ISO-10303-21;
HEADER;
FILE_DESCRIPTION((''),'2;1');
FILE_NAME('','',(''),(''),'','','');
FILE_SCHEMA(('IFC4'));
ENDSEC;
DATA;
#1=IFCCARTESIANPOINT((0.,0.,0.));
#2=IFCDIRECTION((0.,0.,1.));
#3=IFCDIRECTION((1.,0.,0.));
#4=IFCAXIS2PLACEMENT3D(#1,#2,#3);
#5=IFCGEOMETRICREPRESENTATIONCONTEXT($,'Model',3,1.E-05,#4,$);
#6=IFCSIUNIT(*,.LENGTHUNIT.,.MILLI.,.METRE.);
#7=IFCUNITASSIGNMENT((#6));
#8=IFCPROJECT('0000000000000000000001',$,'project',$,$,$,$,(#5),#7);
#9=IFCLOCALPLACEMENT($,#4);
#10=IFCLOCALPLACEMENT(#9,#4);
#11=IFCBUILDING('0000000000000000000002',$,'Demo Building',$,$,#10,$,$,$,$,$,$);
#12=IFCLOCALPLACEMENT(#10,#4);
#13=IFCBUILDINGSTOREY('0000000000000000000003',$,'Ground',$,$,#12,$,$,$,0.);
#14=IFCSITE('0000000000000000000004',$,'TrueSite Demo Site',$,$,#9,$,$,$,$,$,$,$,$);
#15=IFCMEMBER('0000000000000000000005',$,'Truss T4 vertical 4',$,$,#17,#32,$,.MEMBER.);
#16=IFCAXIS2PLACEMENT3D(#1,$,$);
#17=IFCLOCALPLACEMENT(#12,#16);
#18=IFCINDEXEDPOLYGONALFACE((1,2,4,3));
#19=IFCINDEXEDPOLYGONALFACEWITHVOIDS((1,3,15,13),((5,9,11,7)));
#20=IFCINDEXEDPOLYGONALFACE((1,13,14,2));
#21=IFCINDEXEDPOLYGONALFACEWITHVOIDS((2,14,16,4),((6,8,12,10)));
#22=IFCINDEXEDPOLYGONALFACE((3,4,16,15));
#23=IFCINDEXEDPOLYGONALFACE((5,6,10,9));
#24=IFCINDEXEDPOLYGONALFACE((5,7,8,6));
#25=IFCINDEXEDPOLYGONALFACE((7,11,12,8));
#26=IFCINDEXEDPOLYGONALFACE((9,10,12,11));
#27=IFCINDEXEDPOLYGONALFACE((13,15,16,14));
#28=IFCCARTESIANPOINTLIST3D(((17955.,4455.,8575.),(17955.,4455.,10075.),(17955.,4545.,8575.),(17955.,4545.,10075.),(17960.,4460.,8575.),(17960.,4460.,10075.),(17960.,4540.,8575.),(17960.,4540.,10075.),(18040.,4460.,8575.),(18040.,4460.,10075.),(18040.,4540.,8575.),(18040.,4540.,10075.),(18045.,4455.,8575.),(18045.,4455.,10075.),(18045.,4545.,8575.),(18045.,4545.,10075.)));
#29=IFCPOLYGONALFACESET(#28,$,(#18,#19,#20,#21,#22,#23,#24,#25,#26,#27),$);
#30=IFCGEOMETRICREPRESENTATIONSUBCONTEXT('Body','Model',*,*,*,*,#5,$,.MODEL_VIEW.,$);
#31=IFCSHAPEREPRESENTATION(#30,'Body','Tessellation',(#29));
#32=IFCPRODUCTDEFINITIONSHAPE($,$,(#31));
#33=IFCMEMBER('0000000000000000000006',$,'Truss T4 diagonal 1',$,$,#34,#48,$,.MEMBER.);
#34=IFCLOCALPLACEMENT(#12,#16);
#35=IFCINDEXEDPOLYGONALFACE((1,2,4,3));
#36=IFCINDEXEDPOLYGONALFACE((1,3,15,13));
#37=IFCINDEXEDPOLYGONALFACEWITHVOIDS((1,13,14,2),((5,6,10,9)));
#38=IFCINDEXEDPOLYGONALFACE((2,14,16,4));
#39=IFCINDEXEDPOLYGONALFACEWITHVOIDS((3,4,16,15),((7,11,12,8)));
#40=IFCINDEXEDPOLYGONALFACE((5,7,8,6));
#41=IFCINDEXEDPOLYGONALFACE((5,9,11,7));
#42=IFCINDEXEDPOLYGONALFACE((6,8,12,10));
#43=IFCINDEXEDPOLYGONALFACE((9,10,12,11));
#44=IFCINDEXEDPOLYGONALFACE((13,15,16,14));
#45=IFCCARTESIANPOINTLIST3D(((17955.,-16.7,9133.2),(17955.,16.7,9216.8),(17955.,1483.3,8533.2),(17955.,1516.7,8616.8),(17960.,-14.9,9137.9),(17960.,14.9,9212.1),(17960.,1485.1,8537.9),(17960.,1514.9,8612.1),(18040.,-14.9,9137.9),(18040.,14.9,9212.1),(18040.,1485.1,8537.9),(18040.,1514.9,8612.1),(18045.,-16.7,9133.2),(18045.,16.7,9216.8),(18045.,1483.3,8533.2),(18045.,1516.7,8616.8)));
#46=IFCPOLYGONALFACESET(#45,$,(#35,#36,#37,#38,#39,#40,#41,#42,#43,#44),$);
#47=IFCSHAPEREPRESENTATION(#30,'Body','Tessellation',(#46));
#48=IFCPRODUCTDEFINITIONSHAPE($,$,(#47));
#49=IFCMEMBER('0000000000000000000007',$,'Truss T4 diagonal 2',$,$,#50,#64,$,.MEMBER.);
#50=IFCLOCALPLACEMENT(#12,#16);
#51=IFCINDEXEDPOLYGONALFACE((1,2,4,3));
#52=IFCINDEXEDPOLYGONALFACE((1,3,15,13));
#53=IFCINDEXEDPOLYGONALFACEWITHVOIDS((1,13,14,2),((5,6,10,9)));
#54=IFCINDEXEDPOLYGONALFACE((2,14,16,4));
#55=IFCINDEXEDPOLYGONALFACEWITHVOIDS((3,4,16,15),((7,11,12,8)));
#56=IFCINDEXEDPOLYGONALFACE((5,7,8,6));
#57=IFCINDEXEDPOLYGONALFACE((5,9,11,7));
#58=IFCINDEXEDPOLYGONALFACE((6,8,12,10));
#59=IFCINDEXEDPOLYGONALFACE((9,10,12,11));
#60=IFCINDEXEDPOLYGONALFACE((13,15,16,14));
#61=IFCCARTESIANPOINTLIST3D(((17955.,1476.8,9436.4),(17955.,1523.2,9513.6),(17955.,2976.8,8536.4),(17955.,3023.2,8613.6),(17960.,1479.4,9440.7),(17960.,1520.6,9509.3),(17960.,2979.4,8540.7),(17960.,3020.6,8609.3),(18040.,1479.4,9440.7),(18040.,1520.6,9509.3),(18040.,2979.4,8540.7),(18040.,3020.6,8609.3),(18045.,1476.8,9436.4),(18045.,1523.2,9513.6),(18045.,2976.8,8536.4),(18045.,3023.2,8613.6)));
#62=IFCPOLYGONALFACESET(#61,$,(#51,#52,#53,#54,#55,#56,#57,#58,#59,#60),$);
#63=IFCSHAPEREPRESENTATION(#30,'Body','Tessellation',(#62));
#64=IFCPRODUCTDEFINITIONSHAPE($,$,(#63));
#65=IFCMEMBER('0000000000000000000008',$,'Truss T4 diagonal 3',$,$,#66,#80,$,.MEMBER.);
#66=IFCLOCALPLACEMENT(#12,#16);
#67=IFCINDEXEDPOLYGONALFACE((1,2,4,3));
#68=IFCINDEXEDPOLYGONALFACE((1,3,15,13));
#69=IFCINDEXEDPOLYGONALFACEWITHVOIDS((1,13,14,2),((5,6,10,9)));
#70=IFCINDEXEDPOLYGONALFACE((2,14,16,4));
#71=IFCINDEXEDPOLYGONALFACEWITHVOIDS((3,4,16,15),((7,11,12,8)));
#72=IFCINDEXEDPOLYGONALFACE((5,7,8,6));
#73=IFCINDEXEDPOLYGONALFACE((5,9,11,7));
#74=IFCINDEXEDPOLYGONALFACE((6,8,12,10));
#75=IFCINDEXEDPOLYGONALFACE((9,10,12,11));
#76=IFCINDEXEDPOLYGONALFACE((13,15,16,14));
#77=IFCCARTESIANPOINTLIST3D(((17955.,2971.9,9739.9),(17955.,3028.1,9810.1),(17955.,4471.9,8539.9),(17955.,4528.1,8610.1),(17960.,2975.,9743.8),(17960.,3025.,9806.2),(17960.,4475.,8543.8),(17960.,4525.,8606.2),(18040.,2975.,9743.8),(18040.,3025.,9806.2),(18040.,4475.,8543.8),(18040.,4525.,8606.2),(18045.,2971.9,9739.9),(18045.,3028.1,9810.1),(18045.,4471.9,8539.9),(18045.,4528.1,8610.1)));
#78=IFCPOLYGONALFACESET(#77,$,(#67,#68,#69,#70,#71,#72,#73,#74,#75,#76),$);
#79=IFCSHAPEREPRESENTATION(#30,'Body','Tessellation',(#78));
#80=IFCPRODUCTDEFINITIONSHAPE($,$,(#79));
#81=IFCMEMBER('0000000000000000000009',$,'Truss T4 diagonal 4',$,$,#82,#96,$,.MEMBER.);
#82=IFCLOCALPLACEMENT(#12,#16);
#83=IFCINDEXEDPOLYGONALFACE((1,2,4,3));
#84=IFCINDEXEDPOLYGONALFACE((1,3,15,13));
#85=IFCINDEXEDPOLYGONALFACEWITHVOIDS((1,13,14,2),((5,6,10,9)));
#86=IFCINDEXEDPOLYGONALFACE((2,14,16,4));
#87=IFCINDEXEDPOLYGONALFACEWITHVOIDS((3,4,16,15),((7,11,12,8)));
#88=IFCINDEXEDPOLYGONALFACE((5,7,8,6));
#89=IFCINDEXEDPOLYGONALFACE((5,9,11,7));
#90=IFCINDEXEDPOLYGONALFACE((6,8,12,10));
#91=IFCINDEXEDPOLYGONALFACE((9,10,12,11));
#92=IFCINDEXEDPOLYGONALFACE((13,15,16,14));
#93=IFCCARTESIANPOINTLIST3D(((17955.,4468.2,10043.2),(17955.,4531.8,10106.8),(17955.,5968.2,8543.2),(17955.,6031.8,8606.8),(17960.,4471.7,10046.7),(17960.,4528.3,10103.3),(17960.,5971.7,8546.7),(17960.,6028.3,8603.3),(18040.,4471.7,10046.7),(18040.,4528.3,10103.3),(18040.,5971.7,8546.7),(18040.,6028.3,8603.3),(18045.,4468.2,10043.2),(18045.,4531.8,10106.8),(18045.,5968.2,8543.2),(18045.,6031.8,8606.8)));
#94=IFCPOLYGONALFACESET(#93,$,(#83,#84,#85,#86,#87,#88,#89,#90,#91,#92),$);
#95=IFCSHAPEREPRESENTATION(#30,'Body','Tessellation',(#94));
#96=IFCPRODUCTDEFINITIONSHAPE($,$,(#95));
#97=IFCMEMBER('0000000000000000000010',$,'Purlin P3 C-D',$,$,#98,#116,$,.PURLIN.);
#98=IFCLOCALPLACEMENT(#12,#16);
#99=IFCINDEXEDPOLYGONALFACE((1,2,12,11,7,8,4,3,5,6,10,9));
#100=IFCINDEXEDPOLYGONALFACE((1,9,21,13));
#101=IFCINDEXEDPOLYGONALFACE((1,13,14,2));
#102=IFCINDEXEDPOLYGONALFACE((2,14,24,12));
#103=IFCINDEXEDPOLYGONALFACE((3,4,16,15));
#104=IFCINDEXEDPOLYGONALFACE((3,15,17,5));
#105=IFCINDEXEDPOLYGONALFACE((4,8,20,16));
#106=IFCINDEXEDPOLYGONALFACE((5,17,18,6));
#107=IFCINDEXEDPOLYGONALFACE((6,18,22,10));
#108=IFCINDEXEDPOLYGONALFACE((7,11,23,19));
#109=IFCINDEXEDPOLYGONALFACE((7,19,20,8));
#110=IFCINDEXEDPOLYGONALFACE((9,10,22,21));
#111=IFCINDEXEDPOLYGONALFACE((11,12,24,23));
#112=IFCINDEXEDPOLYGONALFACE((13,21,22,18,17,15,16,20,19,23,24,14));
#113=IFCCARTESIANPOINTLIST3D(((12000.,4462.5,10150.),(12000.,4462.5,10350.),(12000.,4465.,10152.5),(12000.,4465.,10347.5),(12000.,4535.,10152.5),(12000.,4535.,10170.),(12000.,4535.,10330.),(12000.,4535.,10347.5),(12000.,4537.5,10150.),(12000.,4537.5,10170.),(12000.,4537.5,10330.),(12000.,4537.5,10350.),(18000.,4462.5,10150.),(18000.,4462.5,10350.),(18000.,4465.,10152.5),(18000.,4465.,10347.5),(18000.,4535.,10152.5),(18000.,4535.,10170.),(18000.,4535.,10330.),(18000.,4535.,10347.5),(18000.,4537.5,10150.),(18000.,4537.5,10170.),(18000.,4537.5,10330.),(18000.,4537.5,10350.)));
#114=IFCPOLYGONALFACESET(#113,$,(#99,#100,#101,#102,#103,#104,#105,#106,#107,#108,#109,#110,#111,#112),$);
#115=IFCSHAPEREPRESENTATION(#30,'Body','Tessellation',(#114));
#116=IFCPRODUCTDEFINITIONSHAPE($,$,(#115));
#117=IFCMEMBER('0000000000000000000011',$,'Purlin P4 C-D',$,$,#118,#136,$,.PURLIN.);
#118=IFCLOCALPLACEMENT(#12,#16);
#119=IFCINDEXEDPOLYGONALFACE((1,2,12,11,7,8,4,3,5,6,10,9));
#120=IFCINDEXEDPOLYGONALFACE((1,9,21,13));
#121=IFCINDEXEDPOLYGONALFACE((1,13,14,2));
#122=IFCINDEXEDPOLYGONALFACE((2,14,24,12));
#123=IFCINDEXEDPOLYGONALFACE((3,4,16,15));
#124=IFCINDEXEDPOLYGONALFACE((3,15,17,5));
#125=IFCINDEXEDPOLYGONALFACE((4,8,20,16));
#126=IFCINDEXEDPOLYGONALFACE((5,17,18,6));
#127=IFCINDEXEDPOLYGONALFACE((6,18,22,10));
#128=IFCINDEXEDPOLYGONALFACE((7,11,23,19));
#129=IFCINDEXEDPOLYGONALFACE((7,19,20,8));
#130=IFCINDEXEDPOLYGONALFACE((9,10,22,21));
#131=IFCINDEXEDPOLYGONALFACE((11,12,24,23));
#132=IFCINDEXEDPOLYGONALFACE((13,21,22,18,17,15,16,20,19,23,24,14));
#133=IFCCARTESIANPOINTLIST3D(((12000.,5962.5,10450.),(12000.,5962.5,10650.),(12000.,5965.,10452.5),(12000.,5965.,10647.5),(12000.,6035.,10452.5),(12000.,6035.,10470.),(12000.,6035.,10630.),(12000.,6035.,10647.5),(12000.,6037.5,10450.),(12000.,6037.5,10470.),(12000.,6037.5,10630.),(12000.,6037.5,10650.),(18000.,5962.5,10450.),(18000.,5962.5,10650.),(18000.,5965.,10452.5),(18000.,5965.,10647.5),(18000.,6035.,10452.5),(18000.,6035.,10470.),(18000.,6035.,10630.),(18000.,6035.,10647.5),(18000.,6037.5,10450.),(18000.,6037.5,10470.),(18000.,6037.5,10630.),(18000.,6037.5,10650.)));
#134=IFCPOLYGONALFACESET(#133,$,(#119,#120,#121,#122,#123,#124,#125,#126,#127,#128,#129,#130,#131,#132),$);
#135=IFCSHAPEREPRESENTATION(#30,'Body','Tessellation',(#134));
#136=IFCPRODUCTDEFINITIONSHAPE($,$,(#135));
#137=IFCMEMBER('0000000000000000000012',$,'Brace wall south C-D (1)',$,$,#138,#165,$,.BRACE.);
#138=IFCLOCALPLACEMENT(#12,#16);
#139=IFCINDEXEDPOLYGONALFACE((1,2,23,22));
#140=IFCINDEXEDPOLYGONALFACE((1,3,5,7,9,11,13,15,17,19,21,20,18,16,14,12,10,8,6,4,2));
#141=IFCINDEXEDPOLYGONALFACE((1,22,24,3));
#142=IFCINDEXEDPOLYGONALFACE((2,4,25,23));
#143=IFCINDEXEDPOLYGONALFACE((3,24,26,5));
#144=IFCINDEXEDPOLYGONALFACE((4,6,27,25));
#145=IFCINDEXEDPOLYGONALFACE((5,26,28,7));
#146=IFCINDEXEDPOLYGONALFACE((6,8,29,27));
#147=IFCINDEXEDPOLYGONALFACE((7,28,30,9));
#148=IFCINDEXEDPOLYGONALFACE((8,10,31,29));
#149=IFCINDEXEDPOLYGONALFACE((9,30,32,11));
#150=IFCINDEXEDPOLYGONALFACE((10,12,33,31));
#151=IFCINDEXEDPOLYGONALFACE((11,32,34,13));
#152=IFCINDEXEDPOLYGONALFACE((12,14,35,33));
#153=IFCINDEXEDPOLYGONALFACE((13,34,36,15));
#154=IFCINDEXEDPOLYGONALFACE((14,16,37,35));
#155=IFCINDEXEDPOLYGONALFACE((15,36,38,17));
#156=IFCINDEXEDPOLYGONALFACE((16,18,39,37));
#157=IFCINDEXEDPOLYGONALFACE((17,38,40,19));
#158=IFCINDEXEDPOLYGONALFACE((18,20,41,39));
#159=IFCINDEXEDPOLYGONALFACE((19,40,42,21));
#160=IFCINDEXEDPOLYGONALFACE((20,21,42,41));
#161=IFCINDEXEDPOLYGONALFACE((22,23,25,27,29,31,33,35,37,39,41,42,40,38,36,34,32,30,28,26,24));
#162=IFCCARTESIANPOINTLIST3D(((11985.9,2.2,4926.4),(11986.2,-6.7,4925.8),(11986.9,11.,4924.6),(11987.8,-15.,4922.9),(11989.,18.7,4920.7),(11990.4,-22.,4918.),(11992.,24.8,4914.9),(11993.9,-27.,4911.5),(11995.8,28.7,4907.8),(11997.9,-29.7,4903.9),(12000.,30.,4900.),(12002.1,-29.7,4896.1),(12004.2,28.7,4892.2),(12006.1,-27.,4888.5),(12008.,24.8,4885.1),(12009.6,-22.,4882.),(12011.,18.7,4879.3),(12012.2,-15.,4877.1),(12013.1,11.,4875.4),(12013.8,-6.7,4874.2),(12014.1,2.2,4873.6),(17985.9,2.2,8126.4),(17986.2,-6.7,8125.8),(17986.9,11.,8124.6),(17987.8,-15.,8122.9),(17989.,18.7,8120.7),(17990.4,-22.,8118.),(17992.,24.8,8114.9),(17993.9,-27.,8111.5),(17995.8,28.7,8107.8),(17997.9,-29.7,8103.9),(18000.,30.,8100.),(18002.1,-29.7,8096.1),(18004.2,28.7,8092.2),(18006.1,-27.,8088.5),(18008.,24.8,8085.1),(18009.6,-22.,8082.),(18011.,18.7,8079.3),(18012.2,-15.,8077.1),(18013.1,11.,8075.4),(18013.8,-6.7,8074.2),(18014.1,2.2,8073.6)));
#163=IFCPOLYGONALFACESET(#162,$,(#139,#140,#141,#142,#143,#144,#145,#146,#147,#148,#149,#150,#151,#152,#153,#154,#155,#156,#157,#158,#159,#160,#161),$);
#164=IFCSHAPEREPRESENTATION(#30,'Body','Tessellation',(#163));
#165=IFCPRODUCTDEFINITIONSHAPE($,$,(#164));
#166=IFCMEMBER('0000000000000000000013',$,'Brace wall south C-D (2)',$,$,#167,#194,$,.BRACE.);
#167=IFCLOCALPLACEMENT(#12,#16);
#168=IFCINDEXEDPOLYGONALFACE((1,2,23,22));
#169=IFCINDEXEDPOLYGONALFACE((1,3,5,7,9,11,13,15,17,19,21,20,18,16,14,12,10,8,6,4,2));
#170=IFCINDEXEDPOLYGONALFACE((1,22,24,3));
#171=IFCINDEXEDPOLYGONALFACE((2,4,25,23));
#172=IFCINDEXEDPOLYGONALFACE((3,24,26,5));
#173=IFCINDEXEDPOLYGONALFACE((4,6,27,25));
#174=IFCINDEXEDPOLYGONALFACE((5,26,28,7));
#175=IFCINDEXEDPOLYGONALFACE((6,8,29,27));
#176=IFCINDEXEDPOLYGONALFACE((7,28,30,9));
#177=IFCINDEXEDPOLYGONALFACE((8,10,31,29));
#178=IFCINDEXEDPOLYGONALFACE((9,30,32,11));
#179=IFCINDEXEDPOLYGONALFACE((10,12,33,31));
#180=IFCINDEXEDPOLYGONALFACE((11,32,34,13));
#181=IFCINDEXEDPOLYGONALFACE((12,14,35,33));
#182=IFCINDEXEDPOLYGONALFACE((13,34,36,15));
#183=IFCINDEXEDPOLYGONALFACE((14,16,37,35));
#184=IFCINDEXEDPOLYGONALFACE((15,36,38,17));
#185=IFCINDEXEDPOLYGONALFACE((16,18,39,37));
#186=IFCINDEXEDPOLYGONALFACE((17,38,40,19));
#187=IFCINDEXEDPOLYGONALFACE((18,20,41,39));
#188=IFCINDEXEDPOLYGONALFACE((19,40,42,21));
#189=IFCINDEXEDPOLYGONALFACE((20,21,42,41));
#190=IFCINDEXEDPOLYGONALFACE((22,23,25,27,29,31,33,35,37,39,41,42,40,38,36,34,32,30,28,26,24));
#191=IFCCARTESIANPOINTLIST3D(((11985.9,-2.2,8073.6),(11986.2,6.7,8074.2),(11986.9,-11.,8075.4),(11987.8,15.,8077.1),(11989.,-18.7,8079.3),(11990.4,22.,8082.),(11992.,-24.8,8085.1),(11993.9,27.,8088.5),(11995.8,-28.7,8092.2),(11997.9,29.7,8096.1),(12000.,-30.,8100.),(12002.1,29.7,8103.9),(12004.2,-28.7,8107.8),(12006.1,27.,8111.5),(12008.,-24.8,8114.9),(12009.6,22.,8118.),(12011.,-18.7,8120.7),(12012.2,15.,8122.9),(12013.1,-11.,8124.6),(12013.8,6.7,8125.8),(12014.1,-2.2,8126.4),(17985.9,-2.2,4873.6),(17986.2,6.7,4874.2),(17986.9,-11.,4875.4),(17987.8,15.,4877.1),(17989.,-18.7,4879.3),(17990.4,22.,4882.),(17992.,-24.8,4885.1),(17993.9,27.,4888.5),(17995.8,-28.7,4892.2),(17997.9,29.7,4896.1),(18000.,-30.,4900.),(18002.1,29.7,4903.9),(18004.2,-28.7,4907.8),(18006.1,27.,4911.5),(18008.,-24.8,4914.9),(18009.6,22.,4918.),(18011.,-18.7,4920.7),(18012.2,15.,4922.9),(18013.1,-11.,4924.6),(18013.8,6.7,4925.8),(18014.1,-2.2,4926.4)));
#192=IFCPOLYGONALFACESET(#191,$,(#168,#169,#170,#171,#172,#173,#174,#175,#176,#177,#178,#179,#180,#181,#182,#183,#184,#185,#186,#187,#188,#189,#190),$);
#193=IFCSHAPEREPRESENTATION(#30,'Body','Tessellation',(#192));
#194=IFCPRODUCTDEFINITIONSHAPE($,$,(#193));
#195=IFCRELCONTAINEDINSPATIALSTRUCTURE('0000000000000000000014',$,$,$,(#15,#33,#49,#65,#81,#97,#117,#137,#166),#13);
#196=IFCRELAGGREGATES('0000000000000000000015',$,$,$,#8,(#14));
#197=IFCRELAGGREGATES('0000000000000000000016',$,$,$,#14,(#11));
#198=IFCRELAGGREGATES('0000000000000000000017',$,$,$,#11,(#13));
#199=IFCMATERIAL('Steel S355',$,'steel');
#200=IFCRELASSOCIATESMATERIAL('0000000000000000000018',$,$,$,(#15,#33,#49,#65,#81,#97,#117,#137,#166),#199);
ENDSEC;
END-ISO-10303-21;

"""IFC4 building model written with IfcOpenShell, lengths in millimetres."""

from ifc_helpers import new_model, si_unit, frame, origin_with_axes, place, context, subcontext, project, spatial, hollow_rectangle, circle, c_section, extrude, material, element, save


model = new_model("IFC4")

# Units and contexts
model_context = context("Model", 3, precision=1e-05, world=origin_with_axes())
body_context = subcontext(model_context, "Body", "Model", "MODEL_VIEW")
ifc_project = project(units=[si_unit("LENGTHUNIT", "METRE", prefix="MILLI")], contexts=[model_context])

# Site, building, storey
site_placement = place(None, origin_with_axes())
site = spatial("IfcSite", under=ifc_project, at=site_placement, Name="TrueSite Demo Site")
building_placement = place(site_placement, origin_with_axes())
building = spatial("IfcBuilding", under=site, at=building_placement, Name="Demo Building")
storey_placement = place(building_placement, origin_with_axes())
storey = spatial("IfcBuildingStorey", under=building, at=storey_placement, Name="Ground", Elevation=0.0)

# Shared definitions
ifc_material_1 = material(Name="Steel S355", Category="steel")

# Members
member_1_placement = place(storey_placement, frame((18000.0, 4500.0, 8575.0), z_axis=(0.0, 0.0, 1.0), x_axis=(1.0, 0.0, 0.0)))
element("IfcMember", 1, at=member_1_placement, inside=storey, material=ifc_material_1, Name="Truss T4 vertical 4", PredefinedType="MEMBER", context=body_context, shape_type="SweptSolid", body=[
    extrude(hollow_rectangle(XDim=90.0, YDim=90.0, WallThickness=5.0), origin_with_axes(), (0.0, 0.0, 1.0), 1500.0),
])
member_2_placement = place(storey_placement, frame((18000.0, 0.0, 9175.0), z_axis=(0.0, 0.928477, -0.371391), x_axis=(-1.0, 0.0, 0.0)))
element("IfcMember", 2, at=member_2_placement, inside=storey, material=ifc_material_1, Name="Truss T4 diagonal 1", PredefinedType="MEMBER", context=body_context, shape_type="SweptSolid", body=[
    extrude(hollow_rectangle(XDim=90.0, YDim=90.0, WallThickness=5.0), origin_with_axes(), (0.0, 0.0, 1.0), 1615.5),
])
member_3_placement = place(storey_placement, frame((18000.0, 1500.0, 9475.0), z_axis=(0.0, 0.857493, -0.514496), x_axis=(-1.0, 0.0, 0.0)))
element("IfcMember", 3, at=member_3_placement, inside=storey, material=ifc_material_1, Name="Truss T4 diagonal 2", PredefinedType="MEMBER", context=body_context, shape_type="SweptSolid", body=[
    extrude(hollow_rectangle(XDim=90.0, YDim=90.0, WallThickness=5.0), origin_with_axes(), (0.0, 0.0, 1.0), 1749.3),
])
member_4_placement = place(storey_placement, frame((18000.0, 3000.0, 9775.0), z_axis=(0.0, 0.780869, -0.624695), x_axis=(-1.0, 0.0, 0.0)))
element("IfcMember", 4, at=member_4_placement, inside=storey, material=ifc_material_1, Name="Truss T4 diagonal 3", PredefinedType="MEMBER", context=body_context, shape_type="SweptSolid", body=[
    extrude(hollow_rectangle(XDim=90.0, YDim=90.0, WallThickness=5.0), origin_with_axes(), (0.0, 0.0, 1.0), 1920.9),
])
member_5_placement = place(storey_placement, frame((18000.0, 4500.0, 10075.0), z_axis=(0.0, 0.707107, -0.707107), x_axis=(-1.0, 0.0, 0.0)))
element("IfcMember", 5, at=member_5_placement, inside=storey, material=ifc_material_1, Name="Truss T4 diagonal 4", PredefinedType="MEMBER", context=body_context, shape_type="SweptSolid", body=[
    extrude(hollow_rectangle(XDim=90.0, YDim=90.0, WallThickness=5.0), origin_with_axes(), (0.0, 0.0, 1.0), 2121.3),
])
for number, where, z_axis, x_axis, name in (
    (6, (12000.0, 4500.0, 10250.0), (1.0, 0.0, 0.0), (0.0, 1.0, 0.0), "Purlin P3 C-D"),
    (7, (12000.0, 6000.0, 10550.0), (1.0, 0.0, 0.0), (0.0, 1.0, 0.0), "Purlin P4 C-D"),
):
    element("IfcMember", number, at=place(storey_placement, frame(where, z_axis=z_axis, x_axis=x_axis)), inside=storey, material=ifc_material_1, Name=name, PredefinedType="PURLIN", context=body_context, shape_type="SweptSolid", body=[
        extrude(c_section(Depth=200.0, Width=75.0, WallThickness=2.5, Girth=20.0), origin_with_axes(), (0.0, 0.0, 1.0), 6000.0),
    ])
for number, where, z_axis, x_axis, name in (
    (8, (12000.0, 0.0, 4900.0), (0.882353, 0.0, 0.470588), (0.0, 1.0, 0.0), "Brace wall south C-D (1)"),
    (9, (18000.0, 0.0, 4900.0), (-0.882353, 0.0, 0.470588), (0.0, -1.0, 0.0), "Brace wall south C-D (2)"),
):
    element("IfcMember", number, at=place(storey_placement, frame(where, z_axis=z_axis, x_axis=x_axis)), inside=storey, material=ifc_material_1, Name=name, PredefinedType="BRACE", context=body_context, shape_type="SweptSolid", body=[
        extrude(circle(Radius=30.0), origin_with_axes(), (0.0, 0.0, 1.0), 6800.0),
    ])

save(model, "model.ifc")
